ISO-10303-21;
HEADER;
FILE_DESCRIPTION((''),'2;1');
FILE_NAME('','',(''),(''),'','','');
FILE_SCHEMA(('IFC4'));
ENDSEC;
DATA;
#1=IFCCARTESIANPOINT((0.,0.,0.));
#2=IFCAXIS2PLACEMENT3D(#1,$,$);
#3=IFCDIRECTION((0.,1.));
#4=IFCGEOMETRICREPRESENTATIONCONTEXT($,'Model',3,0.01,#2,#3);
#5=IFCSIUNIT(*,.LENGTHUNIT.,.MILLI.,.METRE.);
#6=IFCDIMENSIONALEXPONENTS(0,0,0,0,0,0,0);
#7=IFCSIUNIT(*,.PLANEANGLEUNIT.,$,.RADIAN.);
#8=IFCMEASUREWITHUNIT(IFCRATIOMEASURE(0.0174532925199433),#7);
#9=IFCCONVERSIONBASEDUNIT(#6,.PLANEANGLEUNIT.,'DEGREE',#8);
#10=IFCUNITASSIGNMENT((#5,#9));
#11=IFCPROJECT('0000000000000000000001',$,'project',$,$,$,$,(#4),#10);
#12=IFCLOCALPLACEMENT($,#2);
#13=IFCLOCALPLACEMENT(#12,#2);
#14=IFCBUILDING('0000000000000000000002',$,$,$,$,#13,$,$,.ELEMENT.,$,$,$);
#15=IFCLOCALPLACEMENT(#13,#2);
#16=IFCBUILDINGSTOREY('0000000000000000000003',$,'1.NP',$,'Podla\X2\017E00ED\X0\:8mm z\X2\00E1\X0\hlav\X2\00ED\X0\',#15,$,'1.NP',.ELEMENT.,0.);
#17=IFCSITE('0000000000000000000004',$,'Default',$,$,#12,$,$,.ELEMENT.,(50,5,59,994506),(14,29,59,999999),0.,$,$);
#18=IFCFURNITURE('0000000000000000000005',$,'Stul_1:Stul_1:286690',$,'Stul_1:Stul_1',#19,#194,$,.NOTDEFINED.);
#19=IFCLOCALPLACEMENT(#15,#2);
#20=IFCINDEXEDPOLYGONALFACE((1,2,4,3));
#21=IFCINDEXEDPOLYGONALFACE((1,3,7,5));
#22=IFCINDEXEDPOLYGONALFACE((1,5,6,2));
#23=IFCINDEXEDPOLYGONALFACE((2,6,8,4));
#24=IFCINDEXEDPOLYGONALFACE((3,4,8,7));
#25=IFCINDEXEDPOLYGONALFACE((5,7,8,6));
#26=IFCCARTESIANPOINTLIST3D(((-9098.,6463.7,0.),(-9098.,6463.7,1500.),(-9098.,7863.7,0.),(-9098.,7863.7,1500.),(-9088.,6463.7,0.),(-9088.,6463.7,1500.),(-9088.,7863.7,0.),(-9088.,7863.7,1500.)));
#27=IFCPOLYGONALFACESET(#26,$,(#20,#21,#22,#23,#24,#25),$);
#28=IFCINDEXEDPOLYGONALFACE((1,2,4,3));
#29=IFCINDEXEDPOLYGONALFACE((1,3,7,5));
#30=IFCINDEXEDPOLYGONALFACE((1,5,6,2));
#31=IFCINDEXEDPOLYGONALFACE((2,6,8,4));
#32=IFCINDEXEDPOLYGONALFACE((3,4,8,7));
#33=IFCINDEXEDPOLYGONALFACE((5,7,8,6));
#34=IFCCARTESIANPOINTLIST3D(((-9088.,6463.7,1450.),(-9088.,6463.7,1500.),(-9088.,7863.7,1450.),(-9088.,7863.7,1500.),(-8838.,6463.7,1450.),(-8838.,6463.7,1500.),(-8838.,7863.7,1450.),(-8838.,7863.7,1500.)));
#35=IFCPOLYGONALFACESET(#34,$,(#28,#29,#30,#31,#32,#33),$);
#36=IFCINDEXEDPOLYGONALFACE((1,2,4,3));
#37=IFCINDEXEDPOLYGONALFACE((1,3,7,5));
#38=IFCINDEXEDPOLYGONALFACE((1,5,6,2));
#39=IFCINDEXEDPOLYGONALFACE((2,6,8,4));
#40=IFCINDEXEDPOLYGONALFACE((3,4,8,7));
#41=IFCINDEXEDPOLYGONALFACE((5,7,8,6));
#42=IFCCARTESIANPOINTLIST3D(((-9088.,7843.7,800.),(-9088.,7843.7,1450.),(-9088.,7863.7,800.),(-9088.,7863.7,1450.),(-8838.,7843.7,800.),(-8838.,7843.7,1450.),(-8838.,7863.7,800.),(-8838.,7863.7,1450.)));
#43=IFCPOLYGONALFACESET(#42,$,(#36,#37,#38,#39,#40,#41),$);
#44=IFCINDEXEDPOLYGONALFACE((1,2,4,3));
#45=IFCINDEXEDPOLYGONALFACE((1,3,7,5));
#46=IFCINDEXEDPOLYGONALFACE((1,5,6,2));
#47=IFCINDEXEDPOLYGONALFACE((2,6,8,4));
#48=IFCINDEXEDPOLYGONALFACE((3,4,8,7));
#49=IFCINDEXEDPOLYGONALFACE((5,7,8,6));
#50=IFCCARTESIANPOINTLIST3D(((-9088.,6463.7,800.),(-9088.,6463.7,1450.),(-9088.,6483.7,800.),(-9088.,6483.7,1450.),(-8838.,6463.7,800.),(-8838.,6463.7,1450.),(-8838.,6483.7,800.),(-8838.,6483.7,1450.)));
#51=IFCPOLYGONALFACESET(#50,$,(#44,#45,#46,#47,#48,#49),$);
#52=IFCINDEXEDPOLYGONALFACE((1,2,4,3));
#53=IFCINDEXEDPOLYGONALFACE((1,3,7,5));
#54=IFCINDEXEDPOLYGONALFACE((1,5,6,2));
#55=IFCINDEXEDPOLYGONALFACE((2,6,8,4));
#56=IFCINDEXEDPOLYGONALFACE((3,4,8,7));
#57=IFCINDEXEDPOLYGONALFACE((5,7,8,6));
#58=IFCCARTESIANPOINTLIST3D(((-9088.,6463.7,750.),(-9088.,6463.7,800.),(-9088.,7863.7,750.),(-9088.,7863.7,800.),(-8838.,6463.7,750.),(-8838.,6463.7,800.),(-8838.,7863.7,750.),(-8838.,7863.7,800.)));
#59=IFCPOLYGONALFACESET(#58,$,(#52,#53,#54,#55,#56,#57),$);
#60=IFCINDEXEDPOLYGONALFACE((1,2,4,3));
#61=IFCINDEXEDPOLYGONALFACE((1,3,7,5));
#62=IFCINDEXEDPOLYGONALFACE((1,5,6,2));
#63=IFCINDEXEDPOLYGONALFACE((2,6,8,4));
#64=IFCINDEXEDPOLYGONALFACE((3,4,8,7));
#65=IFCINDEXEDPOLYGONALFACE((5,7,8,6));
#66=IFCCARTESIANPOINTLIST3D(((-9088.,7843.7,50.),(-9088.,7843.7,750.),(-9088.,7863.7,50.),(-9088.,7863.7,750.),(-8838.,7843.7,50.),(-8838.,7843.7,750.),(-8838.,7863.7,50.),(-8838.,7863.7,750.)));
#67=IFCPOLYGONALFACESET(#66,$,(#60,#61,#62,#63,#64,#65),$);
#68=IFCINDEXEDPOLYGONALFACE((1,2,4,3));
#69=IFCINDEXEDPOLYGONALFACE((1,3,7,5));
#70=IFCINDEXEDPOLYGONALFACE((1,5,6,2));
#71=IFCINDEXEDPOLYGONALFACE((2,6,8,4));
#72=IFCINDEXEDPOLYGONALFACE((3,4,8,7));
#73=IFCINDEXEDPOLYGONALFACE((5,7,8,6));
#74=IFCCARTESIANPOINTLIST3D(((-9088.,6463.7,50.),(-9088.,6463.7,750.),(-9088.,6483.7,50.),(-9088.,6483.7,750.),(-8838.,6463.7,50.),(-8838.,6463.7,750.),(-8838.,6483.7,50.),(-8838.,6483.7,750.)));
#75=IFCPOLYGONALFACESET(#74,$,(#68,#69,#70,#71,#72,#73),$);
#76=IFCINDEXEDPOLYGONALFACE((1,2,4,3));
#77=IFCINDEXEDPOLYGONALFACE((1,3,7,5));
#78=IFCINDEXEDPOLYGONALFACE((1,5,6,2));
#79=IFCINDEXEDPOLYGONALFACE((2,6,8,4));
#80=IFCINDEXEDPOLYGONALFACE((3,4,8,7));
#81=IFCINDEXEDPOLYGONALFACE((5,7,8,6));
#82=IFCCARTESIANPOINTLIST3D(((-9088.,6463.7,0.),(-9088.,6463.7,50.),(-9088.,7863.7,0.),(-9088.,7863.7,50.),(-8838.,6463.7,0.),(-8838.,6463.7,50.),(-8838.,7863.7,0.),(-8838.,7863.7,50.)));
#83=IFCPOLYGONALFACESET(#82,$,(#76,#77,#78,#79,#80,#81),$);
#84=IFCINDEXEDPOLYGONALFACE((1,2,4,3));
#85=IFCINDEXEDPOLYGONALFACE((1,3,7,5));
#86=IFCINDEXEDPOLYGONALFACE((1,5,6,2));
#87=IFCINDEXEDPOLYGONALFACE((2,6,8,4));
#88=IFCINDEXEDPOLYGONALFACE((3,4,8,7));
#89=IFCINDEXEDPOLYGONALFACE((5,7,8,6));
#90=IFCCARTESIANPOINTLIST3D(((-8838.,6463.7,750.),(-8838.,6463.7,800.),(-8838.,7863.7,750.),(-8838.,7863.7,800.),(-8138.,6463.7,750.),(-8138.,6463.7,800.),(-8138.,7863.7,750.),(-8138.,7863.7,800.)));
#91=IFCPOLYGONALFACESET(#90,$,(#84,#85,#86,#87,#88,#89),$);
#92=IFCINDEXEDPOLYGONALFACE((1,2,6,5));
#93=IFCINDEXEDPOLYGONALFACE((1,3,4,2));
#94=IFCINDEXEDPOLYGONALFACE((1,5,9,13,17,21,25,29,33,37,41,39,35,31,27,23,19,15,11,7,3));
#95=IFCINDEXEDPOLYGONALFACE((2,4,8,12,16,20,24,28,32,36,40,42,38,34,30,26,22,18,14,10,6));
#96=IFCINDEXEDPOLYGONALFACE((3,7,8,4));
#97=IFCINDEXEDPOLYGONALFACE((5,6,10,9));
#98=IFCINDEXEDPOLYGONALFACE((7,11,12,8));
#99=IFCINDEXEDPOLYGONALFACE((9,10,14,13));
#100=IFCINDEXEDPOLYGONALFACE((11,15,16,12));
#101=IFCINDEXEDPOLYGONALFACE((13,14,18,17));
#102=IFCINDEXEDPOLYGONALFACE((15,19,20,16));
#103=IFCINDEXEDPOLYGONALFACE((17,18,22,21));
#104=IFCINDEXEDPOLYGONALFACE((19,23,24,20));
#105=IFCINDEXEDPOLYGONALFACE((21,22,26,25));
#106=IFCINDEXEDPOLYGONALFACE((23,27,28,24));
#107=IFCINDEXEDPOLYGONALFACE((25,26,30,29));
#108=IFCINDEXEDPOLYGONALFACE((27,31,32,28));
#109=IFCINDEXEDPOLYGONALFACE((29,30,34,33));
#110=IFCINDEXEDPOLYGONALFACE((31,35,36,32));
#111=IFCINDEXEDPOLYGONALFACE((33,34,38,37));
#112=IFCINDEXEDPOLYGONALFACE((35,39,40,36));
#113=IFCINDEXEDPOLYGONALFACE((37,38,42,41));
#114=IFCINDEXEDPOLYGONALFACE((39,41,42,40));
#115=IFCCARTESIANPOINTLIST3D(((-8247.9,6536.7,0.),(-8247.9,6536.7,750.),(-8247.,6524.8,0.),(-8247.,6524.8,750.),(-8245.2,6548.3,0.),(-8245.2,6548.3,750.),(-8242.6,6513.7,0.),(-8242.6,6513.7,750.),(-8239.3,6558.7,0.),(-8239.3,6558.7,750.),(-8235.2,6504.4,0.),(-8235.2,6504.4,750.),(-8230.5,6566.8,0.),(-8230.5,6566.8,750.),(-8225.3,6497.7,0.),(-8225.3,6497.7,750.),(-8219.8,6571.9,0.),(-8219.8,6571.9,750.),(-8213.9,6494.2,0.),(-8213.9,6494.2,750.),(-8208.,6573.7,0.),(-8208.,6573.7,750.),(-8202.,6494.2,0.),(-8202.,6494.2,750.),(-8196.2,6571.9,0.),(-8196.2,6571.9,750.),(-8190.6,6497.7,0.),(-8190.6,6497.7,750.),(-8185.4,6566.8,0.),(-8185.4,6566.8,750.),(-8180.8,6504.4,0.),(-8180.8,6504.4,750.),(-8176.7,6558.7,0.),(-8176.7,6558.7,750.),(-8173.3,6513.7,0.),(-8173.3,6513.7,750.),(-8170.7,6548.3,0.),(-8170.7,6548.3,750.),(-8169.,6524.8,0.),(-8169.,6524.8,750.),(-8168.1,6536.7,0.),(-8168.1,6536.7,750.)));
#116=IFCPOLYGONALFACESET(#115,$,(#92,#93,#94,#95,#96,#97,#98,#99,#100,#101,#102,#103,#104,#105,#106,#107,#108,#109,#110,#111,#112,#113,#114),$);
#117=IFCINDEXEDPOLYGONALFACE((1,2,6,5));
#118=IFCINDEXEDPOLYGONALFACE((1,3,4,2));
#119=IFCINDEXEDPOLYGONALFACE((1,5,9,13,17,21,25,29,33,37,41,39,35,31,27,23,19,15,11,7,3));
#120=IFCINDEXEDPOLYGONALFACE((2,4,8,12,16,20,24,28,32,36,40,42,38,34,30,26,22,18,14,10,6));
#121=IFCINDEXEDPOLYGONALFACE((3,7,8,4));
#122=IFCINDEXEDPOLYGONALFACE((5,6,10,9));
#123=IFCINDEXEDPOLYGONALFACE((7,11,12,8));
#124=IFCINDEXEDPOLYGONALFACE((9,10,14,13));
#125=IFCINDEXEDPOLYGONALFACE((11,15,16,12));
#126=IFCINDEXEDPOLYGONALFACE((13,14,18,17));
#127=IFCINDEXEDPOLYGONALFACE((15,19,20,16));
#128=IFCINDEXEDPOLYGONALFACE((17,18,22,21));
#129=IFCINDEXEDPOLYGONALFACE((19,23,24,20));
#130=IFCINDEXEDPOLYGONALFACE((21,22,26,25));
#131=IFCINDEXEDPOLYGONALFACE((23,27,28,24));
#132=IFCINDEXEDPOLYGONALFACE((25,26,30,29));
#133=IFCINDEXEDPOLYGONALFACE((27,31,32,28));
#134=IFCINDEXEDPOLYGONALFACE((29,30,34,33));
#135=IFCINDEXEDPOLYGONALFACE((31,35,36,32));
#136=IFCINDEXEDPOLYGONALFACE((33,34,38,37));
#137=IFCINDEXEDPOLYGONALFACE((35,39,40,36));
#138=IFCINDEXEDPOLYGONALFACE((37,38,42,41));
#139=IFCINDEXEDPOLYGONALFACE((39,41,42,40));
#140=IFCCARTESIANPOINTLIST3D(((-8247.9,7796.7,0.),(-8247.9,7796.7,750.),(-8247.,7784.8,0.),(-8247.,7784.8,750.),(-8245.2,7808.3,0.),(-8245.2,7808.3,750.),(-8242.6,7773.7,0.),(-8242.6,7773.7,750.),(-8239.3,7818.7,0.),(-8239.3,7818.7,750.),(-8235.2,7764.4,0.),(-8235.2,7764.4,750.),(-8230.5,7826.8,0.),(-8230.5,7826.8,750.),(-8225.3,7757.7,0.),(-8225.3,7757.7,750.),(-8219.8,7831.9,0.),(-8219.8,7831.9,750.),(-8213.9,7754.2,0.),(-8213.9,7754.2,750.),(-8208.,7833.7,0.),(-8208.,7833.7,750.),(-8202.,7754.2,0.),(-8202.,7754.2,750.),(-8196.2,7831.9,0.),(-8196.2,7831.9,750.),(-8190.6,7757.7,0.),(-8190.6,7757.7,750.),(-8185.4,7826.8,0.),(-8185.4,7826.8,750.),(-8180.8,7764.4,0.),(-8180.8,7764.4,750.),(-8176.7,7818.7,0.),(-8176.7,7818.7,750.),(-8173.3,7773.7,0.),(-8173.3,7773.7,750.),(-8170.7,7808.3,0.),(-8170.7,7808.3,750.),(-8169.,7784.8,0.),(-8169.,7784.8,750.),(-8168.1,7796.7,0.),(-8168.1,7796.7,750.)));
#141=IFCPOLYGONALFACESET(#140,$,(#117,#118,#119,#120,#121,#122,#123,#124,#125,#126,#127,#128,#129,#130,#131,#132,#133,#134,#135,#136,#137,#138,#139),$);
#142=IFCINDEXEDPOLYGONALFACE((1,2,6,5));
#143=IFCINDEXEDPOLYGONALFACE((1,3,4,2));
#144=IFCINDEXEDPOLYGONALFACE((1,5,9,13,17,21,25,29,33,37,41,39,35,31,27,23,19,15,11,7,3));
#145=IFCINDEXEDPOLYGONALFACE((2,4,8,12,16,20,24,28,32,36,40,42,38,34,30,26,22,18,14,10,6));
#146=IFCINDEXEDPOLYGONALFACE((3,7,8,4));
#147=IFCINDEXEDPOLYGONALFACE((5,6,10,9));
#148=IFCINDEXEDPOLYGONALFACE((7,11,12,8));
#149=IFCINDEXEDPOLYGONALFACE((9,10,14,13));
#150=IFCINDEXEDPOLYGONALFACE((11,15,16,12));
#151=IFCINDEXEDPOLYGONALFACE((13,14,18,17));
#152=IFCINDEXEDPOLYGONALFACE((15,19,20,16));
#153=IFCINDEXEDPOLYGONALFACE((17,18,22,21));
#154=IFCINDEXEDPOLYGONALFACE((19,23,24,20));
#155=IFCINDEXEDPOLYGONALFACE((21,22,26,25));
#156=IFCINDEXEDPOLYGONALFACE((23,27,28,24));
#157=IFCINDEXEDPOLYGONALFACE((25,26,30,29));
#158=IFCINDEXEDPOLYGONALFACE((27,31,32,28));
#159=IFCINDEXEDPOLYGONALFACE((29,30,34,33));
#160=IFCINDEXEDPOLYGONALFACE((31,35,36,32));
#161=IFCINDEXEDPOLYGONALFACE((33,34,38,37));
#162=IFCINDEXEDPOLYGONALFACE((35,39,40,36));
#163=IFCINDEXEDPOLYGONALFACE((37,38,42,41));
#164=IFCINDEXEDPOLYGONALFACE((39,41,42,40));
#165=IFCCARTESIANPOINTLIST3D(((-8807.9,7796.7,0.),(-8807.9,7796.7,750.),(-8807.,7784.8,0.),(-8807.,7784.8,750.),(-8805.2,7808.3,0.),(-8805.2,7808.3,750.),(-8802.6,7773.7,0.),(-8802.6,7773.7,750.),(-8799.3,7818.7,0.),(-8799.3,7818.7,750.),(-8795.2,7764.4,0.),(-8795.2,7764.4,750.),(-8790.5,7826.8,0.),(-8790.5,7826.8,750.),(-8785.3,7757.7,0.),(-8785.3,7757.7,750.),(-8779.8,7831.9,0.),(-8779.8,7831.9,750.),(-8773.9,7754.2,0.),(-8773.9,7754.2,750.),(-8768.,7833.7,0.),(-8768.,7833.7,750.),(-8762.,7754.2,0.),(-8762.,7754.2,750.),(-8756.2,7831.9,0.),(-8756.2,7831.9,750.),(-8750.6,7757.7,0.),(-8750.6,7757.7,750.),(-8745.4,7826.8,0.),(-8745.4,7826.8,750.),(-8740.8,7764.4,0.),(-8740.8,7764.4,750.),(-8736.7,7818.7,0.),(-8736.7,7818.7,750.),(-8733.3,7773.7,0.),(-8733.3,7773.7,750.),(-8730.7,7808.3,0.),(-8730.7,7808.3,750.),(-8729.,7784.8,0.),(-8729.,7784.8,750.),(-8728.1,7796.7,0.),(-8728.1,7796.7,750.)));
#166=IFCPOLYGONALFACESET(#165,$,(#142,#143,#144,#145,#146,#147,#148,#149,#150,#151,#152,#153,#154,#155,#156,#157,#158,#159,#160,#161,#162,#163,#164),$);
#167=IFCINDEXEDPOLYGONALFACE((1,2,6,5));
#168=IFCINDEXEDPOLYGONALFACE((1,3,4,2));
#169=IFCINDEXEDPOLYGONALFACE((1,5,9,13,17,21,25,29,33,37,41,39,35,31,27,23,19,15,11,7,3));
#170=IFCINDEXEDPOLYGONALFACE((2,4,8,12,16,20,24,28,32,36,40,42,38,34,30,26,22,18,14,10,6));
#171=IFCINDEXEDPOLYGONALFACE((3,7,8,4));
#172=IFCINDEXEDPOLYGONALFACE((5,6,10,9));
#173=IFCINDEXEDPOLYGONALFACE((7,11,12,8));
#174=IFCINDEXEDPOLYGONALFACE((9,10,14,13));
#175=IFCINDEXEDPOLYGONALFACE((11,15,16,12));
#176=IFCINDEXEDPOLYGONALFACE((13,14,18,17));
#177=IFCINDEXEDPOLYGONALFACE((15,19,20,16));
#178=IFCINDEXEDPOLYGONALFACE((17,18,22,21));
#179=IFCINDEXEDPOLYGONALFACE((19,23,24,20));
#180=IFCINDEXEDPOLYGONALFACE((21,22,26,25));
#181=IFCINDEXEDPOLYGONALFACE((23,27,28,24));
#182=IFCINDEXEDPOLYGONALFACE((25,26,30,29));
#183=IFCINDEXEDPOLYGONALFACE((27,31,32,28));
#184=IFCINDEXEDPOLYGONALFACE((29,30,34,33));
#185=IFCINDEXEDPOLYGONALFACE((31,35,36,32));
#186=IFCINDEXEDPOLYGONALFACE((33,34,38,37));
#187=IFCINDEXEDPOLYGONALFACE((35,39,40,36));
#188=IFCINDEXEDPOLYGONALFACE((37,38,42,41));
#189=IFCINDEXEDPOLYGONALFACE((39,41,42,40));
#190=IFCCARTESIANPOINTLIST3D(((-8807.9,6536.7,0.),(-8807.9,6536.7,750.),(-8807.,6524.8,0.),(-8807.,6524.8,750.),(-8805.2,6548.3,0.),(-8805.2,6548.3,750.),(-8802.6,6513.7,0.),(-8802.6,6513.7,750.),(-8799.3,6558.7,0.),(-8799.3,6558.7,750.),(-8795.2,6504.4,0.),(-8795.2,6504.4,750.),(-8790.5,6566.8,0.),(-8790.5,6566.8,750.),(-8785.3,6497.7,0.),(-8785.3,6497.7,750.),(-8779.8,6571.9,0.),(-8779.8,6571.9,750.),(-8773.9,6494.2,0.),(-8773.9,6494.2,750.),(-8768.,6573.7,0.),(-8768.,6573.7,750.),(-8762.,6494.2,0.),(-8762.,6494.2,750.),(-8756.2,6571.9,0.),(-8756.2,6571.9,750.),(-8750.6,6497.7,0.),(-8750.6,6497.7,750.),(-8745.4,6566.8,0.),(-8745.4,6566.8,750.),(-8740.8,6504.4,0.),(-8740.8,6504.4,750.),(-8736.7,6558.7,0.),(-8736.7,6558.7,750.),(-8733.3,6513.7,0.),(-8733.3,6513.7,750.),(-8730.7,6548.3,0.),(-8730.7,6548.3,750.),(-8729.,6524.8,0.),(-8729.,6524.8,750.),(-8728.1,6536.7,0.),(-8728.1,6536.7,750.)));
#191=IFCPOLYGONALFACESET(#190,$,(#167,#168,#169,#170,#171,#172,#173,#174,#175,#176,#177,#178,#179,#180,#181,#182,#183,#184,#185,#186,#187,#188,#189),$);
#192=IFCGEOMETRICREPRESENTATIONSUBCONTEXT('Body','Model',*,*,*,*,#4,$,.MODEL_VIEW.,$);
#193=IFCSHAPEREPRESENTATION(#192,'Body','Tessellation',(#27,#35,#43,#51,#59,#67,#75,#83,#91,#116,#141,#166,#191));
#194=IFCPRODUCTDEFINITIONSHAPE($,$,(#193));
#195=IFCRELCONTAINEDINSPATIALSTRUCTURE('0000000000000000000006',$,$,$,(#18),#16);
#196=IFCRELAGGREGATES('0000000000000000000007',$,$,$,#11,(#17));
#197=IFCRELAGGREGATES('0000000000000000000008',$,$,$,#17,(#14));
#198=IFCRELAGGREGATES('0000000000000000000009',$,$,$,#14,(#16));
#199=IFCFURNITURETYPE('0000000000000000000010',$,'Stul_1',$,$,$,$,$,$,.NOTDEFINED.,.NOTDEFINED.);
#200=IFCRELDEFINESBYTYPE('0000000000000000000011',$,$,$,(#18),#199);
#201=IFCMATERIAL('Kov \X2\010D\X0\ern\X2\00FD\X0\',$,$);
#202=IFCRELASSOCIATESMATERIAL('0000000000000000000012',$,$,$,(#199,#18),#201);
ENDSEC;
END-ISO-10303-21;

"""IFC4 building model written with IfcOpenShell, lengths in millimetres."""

from ifc_helpers import new_model, entity, si_unit, converted_unit, direction, frame, frame_2d, origin, origin_2d_with_axis, place, context, subcontext, project, spatial, rectangle, circle, extrude, source, transform, mapped, material, type_object, type_shapes, element, save


model = new_model("IFC4")

# Units and contexts
model_context = context("Model", 3, precision=0.01, world=origin(), true_north=direction((0.0, 1.0)))
body_context = subcontext(model_context, "Body", "Model", "MODEL_VIEW")
ifc_project = project(units=[si_unit("LENGTHUNIT", "METRE", prefix="MILLI"), converted_unit("PLANEANGLEUNIT", "DEGREE", entity("IfcRatioMeasure", 0.0174532925199433), si_unit("PLANEANGLEUNIT", "RADIAN"), dimensions=[0, 0, 0, 0, 0, 0, 0])], contexts=[model_context])

# Site, building, storey
site_placement = place(None, origin())
site = spatial("IfcSite", under=ifc_project, at=site_placement, Name="Default", CompositionType="ELEMENT", RefLatitude=(50, 5, 59, 994506), RefLongitude=(14, 29, 59, 999999), RefElevation=0.0)
building_placement = place(site_placement, origin())
building = spatial("IfcBuilding", under=site, at=building_placement, CompositionType="ELEMENT")
storey_placement = place(building_placement, origin())
storey = spatial("IfcBuildingStorey", under=building, at=storey_placement, Name="1.NP", ObjectType="Podlaží:8mm záhlaví", LongName="1.NP", CompositionType="ELEMENT", Elevation=0.0)

# Furniture
ifc_material_1 = material(Name="Kov černý")
furniture_type = type_object("IfcFurnitureType", Name="Stul_1", AssemblyPlace="NOTDEFINED", PredefinedType="NOTDEFINED", material=ifc_material_1)
shared_shape_1 = source(origin(), body_context, "Body", "SweptSolid", [
    extrude(rectangle(XDim=1400.0, YDim=10.0, at=origin_2d_with_axis()), frame((0.0, 605.0, 0.0), z_axis=(0.0, 0.0, 1.0), x_axis=(-1.0, 0.0, 0.0)), (0.0, 0.0, 1.0), 1500.0),
    extrude(rectangle(XDim=1400.0, YDim=250.0, at=frame_2d((0.0, 0.0), x_axis=(1.0, 0.0))), frame((0.0, 475.0, 1450.0), z_axis=(0.0, 0.0, 1.0), x_axis=(-1.0, 0.0, 0.0)), (0.0, 0.0, 1.0), 50.0),
    extrude(rectangle(XDim=20.0, YDim=250.0, at=origin_2d_with_axis()), frame((690.0, 475.0, 800.0), z_axis=(0.0, 0.0, 1.0), x_axis=(-1.0, 0.0, 0.0)), (0.0, 0.0, 1.0), 650.0),
    extrude(rectangle(XDim=20.0, YDim=250.0, at=frame_2d((0.0, 0.0), x_axis=(1.0, 0.0))), frame((-690.0, 475.0, 800.0), z_axis=(0.0, 0.0, 1.0), x_axis=(-1.0, 0.0, 0.0)), (0.0, 0.0, 1.0), 650.0),
    extrude(rectangle(XDim=1400.0, YDim=250.0, at=origin_2d_with_axis()), frame((0.0, 475.0, 750.0), z_axis=(0.0, 0.0, 1.0), x_axis=(-1.0, 0.0, 0.0)), (0.0, 0.0, 1.0), 50.0),
    extrude(rectangle(XDim=20.0, YDim=250.0, at=origin_2d_with_axis()), frame((690.0, 475.0, 50.0), z_axis=(0.0, 0.0, 1.0), x_axis=(-1.0, 0.0, 0.0)), (0.0, 0.0, 1.0), 700.0),
    extrude(rectangle(XDim=20.0, YDim=250.0, at=frame_2d((0.0, 0.0), x_axis=(1.0, 0.0))), frame((-690.0, 475.0, 50.0), z_axis=(0.0, 0.0, 1.0), x_axis=(-1.0, 0.0, 0.0)), (0.0, 0.0, 1.0), 700.0),
    extrude(rectangle(XDim=1400.0, YDim=250.0, at=origin_2d_with_axis()), frame((0.0, 475.0, 0.0), z_axis=(0.0, 0.0, 1.0), x_axis=(-1.0, 0.0, 0.0)), (0.0, 0.0, 1.0), 50.0),
    extrude(rectangle(XDim=1400.0, YDim=700.0, at=origin_2d_with_axis()), frame((0.0, 0.0, 750.0), z_axis=(0.0, 0.0, 1.0), x_axis=(-1.0, 0.0, 0.0)), (0.0, 0.0, 1.0), 50.0),
    extrude(circle(Radius=40.0, at=frame_2d((0.0, 0.0), x_axis=(1.0, 0.0))), frame((-630.0, -280.0, 0.0)), (0.0, 0.0, 1.0), 750.0),
    extrude(circle(Radius=40.0, at=frame_2d((0.0, 0.0), x_axis=(1.0, 0.0))), frame((630.0, -280.0, 0.0)), (0.0, 0.0, 1.0), 750.0),
    extrude(circle(Radius=40.0, at=frame_2d((0.0, 0.0), x_axis=(1.0, 0.0))), frame((630.0, 280.0, 0.0)), (0.0, 0.0, 1.0), 750.0),
    extrude(circle(Radius=40.0, at=frame_2d((0.0, 0.0), x_axis=(1.0, 0.0))), frame((-630.0, 280.0, 0.0)), (0.0, 0.0, 1.0), 750.0),
])
type_shapes(furniture_type, [shared_shape_1])
for number, where, z_axis, x_axis, name in (
    (1, (-8488.0, 7163.7, 0.0), (0.0, 0.0, 1.0), (0.0, 1.0, 0.0), "Stul_1:Stul_1:286690"),
):
    element("IfcFurniture", number, at=place(storey_placement, frame(where, z_axis=z_axis, x_axis=x_axis)), inside=storey, type_object=furniture_type, material=ifc_material_1, Name=name, ObjectType="Stul_1:Stul_1", PredefinedType="NOTDEFINED", context=body_context, shape_type="MappedRepresentation", body=[
        mapped(shared_shape_1, transform((0.0, 0.0, 0.0), scale=1.0)),
    ])

save(model, "model.ifc")
